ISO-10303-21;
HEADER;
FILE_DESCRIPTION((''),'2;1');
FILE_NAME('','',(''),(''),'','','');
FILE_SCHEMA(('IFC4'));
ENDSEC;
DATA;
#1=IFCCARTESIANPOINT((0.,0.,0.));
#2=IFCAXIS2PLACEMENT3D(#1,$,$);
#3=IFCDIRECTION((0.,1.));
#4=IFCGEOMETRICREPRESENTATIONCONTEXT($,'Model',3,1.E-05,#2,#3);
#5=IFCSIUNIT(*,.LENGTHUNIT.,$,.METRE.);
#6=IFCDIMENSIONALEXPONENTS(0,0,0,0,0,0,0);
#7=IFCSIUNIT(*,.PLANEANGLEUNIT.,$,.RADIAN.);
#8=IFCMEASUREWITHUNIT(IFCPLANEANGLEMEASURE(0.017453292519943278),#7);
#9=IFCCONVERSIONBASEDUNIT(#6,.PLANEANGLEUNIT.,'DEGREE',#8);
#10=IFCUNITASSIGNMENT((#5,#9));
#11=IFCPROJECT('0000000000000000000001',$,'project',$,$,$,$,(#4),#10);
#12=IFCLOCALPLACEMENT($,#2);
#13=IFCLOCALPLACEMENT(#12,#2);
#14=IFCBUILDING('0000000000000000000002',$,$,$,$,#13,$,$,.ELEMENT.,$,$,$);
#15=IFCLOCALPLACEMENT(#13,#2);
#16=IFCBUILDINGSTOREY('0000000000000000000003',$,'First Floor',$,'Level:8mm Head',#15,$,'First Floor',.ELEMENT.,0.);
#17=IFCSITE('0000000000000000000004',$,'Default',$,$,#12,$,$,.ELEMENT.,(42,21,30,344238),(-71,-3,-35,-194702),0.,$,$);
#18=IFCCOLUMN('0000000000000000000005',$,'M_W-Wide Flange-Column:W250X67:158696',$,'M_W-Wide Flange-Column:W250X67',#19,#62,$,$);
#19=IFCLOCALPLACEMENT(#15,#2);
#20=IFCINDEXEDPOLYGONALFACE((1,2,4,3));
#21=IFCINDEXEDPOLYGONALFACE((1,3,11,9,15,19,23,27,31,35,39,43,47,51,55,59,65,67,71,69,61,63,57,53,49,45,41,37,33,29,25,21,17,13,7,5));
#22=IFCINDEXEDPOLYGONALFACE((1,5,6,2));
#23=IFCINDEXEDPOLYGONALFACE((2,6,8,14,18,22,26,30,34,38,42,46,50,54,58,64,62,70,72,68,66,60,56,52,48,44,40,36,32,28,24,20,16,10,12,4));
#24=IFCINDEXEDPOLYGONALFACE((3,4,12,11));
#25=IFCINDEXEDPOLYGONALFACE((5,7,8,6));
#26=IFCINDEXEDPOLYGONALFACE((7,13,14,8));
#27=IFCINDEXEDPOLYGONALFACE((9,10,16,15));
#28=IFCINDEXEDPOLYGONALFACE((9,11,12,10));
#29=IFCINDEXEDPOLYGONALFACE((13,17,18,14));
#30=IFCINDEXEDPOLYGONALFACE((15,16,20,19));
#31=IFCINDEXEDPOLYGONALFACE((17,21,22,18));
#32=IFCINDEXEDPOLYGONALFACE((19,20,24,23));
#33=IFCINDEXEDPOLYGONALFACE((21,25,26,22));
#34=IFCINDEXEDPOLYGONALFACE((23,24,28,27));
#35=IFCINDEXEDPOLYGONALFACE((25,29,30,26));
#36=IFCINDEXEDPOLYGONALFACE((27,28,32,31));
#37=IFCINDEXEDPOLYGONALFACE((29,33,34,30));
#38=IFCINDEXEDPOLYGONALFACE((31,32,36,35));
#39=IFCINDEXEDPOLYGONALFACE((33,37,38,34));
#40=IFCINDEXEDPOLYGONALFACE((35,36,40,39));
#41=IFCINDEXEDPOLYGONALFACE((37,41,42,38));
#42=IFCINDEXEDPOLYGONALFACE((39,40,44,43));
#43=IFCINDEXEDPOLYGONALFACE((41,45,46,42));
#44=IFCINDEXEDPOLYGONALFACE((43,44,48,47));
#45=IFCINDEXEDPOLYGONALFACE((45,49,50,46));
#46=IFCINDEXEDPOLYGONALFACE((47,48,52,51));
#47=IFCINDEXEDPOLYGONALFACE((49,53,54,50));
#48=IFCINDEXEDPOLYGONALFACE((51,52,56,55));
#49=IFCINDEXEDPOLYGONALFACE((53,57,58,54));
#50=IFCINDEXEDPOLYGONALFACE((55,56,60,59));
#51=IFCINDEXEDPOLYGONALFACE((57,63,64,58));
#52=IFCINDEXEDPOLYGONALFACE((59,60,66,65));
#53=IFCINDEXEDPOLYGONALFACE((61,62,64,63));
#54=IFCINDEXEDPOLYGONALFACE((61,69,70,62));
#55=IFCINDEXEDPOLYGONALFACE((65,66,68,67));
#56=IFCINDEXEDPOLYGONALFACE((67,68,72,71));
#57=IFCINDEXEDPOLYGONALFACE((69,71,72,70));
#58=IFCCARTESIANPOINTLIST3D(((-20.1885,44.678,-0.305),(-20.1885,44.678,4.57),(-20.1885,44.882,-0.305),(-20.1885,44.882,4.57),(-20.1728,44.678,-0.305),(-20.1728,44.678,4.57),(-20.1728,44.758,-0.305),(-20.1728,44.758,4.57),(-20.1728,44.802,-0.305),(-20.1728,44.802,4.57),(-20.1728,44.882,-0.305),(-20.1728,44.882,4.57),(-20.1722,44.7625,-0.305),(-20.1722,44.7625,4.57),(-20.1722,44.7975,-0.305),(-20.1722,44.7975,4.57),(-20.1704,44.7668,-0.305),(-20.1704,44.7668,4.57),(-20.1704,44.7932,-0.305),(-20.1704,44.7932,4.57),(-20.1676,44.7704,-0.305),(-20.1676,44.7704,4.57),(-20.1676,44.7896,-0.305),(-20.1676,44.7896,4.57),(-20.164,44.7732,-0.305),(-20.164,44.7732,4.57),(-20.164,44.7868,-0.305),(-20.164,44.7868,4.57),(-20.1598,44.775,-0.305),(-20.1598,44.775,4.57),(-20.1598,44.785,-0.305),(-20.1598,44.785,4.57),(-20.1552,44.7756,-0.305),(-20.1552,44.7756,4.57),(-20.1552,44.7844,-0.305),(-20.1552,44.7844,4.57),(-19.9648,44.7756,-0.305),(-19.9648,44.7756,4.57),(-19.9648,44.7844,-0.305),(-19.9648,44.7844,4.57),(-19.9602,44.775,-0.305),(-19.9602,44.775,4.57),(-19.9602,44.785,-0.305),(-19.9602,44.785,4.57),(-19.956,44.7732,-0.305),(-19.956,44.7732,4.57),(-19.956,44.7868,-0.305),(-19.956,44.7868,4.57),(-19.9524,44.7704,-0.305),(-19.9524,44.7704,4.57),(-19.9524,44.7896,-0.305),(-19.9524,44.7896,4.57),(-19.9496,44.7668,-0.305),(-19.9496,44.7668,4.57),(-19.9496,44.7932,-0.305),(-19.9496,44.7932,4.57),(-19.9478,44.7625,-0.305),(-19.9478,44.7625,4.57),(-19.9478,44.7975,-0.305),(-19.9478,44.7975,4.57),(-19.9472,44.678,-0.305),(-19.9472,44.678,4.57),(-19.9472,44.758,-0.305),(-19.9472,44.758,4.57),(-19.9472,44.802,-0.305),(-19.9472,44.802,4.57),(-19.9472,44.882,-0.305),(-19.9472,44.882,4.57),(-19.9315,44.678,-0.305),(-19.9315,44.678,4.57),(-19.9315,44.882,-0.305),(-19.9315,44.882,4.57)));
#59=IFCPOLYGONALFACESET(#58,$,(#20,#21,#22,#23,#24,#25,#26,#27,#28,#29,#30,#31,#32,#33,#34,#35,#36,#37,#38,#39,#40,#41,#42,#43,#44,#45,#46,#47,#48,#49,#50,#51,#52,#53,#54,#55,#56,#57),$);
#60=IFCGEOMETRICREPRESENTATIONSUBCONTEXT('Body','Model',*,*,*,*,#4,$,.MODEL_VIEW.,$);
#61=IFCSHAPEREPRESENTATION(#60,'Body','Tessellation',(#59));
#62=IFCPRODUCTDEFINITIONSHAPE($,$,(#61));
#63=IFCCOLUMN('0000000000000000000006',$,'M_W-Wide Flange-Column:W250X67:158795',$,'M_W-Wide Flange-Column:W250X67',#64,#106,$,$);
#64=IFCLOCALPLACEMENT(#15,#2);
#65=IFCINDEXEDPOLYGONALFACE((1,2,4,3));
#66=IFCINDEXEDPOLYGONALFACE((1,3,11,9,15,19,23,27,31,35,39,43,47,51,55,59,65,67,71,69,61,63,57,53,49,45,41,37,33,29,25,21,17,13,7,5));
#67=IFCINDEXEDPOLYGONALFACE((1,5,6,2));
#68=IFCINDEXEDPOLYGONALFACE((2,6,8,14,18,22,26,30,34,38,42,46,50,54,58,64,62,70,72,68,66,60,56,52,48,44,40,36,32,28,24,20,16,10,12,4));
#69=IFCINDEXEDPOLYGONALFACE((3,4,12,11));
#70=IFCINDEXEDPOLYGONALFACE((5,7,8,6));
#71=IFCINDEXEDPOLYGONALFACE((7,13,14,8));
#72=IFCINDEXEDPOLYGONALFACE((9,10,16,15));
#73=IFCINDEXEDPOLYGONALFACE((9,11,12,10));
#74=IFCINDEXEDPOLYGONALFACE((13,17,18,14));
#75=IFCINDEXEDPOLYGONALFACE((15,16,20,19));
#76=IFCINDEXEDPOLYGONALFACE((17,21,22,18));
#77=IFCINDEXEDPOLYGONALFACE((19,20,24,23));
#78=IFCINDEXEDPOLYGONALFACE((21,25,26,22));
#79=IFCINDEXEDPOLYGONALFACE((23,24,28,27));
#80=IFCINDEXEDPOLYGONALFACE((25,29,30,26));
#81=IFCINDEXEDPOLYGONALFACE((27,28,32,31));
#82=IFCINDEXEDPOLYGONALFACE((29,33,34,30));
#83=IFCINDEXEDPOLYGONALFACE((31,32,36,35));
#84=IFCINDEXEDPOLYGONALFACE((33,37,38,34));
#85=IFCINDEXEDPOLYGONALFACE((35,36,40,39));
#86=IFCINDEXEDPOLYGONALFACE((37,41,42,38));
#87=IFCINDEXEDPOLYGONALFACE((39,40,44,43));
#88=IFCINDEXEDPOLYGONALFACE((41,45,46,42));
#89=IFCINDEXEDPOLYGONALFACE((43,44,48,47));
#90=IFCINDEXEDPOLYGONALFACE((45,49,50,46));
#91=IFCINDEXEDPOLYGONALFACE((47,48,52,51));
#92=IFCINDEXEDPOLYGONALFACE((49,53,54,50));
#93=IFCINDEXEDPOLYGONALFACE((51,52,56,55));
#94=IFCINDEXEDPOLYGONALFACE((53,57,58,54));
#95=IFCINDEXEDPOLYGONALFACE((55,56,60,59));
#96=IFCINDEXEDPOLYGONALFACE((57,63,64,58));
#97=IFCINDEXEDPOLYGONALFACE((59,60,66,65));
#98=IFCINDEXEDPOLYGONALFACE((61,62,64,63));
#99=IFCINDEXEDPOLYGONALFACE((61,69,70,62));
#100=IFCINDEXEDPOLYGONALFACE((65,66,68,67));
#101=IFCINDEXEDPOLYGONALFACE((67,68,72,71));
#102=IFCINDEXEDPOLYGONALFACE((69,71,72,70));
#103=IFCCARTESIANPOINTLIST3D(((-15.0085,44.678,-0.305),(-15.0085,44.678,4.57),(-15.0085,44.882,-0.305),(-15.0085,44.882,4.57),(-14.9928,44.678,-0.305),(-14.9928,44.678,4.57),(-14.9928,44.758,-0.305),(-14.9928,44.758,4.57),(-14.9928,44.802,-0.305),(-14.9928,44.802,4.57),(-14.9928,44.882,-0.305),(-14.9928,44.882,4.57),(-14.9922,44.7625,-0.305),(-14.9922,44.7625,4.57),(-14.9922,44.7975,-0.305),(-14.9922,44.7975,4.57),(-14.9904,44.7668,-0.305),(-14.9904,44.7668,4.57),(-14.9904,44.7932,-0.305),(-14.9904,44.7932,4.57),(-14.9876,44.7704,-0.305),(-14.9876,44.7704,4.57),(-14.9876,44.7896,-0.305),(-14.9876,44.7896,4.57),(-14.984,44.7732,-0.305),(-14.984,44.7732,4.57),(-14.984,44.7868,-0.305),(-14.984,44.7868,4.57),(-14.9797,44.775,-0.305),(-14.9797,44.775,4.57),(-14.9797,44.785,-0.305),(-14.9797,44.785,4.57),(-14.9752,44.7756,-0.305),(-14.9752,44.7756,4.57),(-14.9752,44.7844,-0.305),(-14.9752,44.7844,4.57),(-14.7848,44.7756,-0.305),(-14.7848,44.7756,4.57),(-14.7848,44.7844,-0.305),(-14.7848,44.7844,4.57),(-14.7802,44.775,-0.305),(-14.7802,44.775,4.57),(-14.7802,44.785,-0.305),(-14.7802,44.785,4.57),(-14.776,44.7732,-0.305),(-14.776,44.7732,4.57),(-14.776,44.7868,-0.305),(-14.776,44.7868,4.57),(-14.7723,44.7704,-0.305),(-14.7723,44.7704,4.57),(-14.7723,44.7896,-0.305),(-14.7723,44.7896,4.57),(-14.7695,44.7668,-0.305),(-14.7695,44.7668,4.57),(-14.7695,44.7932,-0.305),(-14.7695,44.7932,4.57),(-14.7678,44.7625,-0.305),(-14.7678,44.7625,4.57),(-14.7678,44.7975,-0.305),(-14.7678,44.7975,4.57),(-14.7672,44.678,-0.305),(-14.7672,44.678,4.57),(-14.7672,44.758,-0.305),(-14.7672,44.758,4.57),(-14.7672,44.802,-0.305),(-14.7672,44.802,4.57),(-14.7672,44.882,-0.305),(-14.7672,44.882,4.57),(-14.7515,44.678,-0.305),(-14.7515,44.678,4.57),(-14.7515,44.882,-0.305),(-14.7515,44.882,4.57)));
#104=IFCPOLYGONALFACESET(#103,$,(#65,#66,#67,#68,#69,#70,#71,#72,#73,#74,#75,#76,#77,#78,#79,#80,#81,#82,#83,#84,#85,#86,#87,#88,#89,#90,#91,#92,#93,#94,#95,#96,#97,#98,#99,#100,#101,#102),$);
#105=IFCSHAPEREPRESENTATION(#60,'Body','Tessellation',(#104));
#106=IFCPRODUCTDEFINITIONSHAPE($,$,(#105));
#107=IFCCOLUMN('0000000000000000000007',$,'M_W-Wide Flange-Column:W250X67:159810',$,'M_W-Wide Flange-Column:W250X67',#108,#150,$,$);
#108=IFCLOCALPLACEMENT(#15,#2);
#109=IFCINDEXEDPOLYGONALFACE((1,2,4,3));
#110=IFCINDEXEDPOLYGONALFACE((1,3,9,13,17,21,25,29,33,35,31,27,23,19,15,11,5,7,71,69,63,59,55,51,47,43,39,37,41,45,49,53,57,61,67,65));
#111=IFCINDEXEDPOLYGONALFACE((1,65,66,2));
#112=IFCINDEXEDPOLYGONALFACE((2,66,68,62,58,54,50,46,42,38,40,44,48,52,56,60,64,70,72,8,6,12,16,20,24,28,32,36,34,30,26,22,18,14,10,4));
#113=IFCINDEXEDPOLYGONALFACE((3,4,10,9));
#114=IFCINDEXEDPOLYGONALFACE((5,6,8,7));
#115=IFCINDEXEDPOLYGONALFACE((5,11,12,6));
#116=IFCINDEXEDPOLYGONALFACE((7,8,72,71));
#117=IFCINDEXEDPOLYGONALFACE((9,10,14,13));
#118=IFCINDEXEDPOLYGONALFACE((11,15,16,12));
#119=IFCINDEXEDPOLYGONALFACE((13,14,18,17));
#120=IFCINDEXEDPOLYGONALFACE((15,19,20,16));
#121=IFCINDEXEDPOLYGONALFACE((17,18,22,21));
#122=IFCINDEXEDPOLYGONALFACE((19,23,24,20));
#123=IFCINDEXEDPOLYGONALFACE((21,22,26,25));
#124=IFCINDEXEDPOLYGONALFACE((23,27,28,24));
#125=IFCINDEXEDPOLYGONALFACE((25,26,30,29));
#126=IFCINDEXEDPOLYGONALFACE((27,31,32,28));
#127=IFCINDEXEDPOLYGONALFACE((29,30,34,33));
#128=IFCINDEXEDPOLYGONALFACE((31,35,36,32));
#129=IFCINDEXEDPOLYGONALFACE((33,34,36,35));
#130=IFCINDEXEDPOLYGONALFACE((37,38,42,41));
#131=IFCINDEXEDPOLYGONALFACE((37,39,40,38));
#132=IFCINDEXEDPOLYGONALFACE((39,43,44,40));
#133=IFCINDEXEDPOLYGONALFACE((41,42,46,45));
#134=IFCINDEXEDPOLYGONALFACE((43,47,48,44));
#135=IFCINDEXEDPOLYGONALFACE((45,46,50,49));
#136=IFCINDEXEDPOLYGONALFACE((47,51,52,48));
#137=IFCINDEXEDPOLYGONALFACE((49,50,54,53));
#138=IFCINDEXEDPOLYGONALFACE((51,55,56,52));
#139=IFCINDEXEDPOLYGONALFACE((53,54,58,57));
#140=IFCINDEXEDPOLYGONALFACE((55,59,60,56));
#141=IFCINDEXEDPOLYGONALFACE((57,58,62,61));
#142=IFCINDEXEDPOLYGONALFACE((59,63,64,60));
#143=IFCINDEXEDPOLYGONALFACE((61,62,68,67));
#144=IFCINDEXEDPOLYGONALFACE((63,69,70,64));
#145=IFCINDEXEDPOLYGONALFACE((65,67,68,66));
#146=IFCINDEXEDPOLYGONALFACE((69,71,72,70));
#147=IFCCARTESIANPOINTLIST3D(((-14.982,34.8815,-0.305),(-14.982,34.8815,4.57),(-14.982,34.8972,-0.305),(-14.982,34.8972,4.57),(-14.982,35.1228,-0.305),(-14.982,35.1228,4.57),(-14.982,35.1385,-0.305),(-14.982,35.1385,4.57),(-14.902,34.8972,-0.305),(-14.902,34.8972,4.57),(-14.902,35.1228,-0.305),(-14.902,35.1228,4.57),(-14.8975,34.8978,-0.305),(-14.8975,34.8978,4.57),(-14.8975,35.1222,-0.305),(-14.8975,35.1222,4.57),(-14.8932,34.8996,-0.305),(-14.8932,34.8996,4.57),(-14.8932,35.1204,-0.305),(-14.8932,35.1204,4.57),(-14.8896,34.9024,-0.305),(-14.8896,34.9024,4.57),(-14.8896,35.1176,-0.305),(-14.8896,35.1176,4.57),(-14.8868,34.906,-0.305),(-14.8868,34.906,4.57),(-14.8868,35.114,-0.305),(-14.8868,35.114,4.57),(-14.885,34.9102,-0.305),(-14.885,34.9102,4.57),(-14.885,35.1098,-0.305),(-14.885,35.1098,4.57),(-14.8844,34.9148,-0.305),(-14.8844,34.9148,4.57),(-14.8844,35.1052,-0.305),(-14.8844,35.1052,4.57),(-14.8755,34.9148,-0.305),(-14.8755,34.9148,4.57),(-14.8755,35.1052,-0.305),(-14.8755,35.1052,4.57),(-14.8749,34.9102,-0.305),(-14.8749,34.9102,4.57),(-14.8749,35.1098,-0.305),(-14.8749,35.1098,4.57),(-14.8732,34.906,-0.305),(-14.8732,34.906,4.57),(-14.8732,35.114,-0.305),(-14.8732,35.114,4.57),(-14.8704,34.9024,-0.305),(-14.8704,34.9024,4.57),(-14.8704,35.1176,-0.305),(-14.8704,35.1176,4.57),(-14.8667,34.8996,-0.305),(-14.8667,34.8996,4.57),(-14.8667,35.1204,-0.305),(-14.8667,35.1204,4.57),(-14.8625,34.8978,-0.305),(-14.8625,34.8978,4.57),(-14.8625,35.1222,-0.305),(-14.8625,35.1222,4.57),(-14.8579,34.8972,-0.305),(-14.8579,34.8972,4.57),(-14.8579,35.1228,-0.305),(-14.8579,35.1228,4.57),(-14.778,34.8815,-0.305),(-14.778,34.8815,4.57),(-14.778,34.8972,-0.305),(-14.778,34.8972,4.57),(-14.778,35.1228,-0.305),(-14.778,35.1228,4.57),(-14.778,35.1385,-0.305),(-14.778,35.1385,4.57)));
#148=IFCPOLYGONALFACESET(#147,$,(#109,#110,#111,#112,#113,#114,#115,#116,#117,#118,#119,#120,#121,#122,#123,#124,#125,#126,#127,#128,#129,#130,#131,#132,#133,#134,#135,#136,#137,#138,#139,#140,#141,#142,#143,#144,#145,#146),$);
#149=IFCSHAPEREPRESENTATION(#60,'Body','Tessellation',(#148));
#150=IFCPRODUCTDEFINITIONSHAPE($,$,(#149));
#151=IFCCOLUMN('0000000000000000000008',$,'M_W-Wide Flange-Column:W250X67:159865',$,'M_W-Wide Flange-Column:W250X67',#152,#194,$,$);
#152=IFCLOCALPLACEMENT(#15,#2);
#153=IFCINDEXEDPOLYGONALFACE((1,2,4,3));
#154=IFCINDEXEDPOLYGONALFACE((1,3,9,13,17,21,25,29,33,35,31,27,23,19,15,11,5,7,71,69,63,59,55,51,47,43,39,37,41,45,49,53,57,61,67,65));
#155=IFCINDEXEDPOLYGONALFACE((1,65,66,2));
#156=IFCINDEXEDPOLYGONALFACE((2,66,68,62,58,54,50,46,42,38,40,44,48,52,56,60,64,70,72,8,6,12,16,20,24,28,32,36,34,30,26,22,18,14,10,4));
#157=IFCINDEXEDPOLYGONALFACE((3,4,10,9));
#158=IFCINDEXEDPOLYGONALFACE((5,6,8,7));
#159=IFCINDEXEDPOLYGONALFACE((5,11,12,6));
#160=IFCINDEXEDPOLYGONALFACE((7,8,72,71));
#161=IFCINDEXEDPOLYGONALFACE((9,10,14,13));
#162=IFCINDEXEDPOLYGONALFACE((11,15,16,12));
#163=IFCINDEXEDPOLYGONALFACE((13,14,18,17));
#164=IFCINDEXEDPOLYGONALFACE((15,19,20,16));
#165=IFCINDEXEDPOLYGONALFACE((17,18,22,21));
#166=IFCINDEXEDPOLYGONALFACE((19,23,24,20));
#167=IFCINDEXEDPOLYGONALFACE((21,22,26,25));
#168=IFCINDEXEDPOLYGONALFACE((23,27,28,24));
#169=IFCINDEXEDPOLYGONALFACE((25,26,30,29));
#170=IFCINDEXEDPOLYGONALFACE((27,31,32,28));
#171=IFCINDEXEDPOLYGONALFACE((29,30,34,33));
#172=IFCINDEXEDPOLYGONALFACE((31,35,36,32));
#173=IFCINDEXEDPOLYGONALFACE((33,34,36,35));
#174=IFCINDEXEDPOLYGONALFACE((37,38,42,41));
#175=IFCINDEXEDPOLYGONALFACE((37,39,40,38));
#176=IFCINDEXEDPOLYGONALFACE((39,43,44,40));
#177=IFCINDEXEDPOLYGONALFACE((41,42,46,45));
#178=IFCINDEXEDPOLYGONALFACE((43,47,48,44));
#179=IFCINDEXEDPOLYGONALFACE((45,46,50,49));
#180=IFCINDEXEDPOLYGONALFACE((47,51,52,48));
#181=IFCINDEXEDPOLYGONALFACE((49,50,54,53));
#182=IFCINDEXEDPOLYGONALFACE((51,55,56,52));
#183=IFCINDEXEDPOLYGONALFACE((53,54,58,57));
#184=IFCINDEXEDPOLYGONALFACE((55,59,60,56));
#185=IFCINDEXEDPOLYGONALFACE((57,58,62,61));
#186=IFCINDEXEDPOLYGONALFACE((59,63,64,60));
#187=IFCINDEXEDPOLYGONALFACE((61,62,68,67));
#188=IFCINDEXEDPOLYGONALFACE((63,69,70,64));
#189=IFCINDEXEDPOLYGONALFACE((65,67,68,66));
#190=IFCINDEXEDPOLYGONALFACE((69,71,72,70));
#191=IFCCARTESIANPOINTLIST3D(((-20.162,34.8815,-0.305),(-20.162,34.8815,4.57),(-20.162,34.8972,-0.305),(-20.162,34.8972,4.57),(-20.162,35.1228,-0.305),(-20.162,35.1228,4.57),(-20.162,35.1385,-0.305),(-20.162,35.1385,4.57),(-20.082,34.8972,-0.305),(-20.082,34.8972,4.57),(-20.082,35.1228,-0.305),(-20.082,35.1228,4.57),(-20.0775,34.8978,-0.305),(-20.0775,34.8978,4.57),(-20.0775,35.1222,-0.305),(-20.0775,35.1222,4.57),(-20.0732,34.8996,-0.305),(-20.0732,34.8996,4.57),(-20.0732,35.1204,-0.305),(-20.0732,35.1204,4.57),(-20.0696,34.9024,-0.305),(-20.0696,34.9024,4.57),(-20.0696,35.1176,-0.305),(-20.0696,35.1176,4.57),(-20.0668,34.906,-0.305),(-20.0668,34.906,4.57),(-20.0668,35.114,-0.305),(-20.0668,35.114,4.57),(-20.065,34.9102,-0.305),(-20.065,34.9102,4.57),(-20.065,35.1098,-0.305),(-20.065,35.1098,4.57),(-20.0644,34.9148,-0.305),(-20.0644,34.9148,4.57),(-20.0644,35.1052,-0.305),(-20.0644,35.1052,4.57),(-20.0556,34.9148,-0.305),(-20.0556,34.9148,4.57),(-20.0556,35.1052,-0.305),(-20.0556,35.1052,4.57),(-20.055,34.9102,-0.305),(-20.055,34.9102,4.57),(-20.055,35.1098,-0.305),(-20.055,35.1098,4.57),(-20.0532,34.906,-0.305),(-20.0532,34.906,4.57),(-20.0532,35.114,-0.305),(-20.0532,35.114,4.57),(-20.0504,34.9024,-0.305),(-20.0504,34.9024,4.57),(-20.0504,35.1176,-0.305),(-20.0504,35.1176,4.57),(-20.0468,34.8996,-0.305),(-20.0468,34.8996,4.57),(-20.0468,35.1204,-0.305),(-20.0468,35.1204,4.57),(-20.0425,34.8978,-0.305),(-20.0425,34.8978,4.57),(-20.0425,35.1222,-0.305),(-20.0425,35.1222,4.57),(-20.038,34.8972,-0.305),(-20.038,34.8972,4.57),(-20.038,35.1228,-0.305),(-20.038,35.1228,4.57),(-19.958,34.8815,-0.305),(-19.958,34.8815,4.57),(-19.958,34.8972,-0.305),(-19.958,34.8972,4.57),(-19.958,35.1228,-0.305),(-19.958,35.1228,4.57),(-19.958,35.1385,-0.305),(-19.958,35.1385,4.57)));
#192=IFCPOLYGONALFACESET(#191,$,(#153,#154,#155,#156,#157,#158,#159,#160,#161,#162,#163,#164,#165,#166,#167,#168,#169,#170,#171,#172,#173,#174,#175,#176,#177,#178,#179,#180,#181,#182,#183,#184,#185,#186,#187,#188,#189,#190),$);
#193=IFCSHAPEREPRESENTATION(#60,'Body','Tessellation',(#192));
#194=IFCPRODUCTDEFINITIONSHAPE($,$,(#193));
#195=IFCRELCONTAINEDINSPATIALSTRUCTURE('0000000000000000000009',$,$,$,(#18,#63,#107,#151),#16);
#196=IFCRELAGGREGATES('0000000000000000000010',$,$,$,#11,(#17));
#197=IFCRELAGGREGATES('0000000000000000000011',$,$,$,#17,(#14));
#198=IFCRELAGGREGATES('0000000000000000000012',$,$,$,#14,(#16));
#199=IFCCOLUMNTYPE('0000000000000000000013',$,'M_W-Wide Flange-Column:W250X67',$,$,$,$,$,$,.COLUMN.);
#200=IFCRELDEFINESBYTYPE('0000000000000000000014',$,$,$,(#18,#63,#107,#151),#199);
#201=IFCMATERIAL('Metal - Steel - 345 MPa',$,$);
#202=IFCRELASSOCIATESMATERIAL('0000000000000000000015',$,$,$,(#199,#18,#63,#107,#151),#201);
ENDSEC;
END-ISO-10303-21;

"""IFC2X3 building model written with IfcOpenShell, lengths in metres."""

from ifc_helpers import new_model, entity, si_unit, converted_unit, direction, frame, frame_2d, origin, place, context, subcontext, project, spatial, i_section, extrude, source, transform, mapped, material, type_object, type_shapes, element, save


model = new_model("IFC2X3")

# Units and contexts
model_context = context("Model", 3, precision=1e-05, world=origin(), true_north=direction((0.0, 1.0)))
body_context = subcontext(model_context, "Body", "Model", "MODEL_VIEW")
ifc_project = project(units=[si_unit("LENGTHUNIT", "METRE"), converted_unit("PLANEANGLEUNIT", "DEGREE", entity("IfcPlaneAngleMeasure", 0.017453292519943278), si_unit("PLANEANGLEUNIT", "RADIAN"), dimensions=[0, 0, 0, 0, 0, 0, 0])], contexts=[model_context])

# Site, building, storey
site_placement = place(None, origin())
site = spatial("IfcSite", under=ifc_project, at=site_placement, Name="Default", CompositionType="ELEMENT", RefLatitude=(42, 21, 30, 344238), RefLongitude=(-71, -3, -35, -194702), RefElevation=0.0)
building_placement = place(site_placement, origin())
building = spatial("IfcBuilding", under=site, at=building_placement, CompositionType="ELEMENT")
storey_placement = place(building_placement, origin())
storey = spatial("IfcBuildingStorey", under=building, at=storey_placement, Name="First Floor", ObjectType="Level:8mm Head", LongName="First Floor", CompositionType="ELEMENT", Elevation=0.0)

# Columns
ifc_material_1 = material(Name="Metal - Steel - 345 MPa")
column_type = type_object("IfcColumnType", Name="M_W-Wide Flange-Column:W250X67", PredefinedType="COLUMN", material=ifc_material_1)
shared_shape_1 = source(origin(), body_context, "Body", "SweptSolid", [
    extrude(i_section(OverallWidth=0.204, OverallDepth=0.257, WebThickness=0.0089, FlangeThickness=0.0157, FilletRadius=0.0176, at=frame_2d((0.0, 0.0), x_axis=(1.0, 0.0))), frame((0.0, 0.0, -0.305), z_axis=(0.0, 0.0, 1.0), x_axis=(-1.0, 0.0, 0.0)), (0.0, 0.0, 1.0), 4.875),
])
type_shapes(column_type, [shared_shape_1])
for number, where, z_axis, x_axis, name in (
    (1, (-20.06, 44.78, 0.0), (0.0, 0.0, 1.0), (0.0, 1.0, 0.0), "M_W-Wide Flange-Column:W250X67:158696"),
    (2, (-14.88, 44.78, 0.0), (0.0, 0.0, 1.0), (0.0, 1.0, 0.0), "M_W-Wide Flange-Column:W250X67:158795"),
    (3, (-14.88, 35.01, 0.0), (0.0, 0.0, 1.0), (-1.0, 0.0, 0.0), "M_W-Wide Flange-Column:W250X67:159810"),
    (4, (-20.06, 35.01, 0.0), (0.0, 0.0, 1.0), (-1.0, 0.0, 0.0), "M_W-Wide Flange-Column:W250X67:159865"),
):
    element("IfcColumn", number, at=place(storey_placement, frame(where, z_axis=z_axis, x_axis=x_axis)), inside=storey, type_object=column_type, material=ifc_material_1, Name=name, ObjectType="M_W-Wide Flange-Column:W250X67", context=body_context, shape_type="MappedRepresentation", body=[
        mapped(shared_shape_1, transform((0.0, 0.0, 0.0), scale=1.0)),
    ])

save(model, "model.ifc")
